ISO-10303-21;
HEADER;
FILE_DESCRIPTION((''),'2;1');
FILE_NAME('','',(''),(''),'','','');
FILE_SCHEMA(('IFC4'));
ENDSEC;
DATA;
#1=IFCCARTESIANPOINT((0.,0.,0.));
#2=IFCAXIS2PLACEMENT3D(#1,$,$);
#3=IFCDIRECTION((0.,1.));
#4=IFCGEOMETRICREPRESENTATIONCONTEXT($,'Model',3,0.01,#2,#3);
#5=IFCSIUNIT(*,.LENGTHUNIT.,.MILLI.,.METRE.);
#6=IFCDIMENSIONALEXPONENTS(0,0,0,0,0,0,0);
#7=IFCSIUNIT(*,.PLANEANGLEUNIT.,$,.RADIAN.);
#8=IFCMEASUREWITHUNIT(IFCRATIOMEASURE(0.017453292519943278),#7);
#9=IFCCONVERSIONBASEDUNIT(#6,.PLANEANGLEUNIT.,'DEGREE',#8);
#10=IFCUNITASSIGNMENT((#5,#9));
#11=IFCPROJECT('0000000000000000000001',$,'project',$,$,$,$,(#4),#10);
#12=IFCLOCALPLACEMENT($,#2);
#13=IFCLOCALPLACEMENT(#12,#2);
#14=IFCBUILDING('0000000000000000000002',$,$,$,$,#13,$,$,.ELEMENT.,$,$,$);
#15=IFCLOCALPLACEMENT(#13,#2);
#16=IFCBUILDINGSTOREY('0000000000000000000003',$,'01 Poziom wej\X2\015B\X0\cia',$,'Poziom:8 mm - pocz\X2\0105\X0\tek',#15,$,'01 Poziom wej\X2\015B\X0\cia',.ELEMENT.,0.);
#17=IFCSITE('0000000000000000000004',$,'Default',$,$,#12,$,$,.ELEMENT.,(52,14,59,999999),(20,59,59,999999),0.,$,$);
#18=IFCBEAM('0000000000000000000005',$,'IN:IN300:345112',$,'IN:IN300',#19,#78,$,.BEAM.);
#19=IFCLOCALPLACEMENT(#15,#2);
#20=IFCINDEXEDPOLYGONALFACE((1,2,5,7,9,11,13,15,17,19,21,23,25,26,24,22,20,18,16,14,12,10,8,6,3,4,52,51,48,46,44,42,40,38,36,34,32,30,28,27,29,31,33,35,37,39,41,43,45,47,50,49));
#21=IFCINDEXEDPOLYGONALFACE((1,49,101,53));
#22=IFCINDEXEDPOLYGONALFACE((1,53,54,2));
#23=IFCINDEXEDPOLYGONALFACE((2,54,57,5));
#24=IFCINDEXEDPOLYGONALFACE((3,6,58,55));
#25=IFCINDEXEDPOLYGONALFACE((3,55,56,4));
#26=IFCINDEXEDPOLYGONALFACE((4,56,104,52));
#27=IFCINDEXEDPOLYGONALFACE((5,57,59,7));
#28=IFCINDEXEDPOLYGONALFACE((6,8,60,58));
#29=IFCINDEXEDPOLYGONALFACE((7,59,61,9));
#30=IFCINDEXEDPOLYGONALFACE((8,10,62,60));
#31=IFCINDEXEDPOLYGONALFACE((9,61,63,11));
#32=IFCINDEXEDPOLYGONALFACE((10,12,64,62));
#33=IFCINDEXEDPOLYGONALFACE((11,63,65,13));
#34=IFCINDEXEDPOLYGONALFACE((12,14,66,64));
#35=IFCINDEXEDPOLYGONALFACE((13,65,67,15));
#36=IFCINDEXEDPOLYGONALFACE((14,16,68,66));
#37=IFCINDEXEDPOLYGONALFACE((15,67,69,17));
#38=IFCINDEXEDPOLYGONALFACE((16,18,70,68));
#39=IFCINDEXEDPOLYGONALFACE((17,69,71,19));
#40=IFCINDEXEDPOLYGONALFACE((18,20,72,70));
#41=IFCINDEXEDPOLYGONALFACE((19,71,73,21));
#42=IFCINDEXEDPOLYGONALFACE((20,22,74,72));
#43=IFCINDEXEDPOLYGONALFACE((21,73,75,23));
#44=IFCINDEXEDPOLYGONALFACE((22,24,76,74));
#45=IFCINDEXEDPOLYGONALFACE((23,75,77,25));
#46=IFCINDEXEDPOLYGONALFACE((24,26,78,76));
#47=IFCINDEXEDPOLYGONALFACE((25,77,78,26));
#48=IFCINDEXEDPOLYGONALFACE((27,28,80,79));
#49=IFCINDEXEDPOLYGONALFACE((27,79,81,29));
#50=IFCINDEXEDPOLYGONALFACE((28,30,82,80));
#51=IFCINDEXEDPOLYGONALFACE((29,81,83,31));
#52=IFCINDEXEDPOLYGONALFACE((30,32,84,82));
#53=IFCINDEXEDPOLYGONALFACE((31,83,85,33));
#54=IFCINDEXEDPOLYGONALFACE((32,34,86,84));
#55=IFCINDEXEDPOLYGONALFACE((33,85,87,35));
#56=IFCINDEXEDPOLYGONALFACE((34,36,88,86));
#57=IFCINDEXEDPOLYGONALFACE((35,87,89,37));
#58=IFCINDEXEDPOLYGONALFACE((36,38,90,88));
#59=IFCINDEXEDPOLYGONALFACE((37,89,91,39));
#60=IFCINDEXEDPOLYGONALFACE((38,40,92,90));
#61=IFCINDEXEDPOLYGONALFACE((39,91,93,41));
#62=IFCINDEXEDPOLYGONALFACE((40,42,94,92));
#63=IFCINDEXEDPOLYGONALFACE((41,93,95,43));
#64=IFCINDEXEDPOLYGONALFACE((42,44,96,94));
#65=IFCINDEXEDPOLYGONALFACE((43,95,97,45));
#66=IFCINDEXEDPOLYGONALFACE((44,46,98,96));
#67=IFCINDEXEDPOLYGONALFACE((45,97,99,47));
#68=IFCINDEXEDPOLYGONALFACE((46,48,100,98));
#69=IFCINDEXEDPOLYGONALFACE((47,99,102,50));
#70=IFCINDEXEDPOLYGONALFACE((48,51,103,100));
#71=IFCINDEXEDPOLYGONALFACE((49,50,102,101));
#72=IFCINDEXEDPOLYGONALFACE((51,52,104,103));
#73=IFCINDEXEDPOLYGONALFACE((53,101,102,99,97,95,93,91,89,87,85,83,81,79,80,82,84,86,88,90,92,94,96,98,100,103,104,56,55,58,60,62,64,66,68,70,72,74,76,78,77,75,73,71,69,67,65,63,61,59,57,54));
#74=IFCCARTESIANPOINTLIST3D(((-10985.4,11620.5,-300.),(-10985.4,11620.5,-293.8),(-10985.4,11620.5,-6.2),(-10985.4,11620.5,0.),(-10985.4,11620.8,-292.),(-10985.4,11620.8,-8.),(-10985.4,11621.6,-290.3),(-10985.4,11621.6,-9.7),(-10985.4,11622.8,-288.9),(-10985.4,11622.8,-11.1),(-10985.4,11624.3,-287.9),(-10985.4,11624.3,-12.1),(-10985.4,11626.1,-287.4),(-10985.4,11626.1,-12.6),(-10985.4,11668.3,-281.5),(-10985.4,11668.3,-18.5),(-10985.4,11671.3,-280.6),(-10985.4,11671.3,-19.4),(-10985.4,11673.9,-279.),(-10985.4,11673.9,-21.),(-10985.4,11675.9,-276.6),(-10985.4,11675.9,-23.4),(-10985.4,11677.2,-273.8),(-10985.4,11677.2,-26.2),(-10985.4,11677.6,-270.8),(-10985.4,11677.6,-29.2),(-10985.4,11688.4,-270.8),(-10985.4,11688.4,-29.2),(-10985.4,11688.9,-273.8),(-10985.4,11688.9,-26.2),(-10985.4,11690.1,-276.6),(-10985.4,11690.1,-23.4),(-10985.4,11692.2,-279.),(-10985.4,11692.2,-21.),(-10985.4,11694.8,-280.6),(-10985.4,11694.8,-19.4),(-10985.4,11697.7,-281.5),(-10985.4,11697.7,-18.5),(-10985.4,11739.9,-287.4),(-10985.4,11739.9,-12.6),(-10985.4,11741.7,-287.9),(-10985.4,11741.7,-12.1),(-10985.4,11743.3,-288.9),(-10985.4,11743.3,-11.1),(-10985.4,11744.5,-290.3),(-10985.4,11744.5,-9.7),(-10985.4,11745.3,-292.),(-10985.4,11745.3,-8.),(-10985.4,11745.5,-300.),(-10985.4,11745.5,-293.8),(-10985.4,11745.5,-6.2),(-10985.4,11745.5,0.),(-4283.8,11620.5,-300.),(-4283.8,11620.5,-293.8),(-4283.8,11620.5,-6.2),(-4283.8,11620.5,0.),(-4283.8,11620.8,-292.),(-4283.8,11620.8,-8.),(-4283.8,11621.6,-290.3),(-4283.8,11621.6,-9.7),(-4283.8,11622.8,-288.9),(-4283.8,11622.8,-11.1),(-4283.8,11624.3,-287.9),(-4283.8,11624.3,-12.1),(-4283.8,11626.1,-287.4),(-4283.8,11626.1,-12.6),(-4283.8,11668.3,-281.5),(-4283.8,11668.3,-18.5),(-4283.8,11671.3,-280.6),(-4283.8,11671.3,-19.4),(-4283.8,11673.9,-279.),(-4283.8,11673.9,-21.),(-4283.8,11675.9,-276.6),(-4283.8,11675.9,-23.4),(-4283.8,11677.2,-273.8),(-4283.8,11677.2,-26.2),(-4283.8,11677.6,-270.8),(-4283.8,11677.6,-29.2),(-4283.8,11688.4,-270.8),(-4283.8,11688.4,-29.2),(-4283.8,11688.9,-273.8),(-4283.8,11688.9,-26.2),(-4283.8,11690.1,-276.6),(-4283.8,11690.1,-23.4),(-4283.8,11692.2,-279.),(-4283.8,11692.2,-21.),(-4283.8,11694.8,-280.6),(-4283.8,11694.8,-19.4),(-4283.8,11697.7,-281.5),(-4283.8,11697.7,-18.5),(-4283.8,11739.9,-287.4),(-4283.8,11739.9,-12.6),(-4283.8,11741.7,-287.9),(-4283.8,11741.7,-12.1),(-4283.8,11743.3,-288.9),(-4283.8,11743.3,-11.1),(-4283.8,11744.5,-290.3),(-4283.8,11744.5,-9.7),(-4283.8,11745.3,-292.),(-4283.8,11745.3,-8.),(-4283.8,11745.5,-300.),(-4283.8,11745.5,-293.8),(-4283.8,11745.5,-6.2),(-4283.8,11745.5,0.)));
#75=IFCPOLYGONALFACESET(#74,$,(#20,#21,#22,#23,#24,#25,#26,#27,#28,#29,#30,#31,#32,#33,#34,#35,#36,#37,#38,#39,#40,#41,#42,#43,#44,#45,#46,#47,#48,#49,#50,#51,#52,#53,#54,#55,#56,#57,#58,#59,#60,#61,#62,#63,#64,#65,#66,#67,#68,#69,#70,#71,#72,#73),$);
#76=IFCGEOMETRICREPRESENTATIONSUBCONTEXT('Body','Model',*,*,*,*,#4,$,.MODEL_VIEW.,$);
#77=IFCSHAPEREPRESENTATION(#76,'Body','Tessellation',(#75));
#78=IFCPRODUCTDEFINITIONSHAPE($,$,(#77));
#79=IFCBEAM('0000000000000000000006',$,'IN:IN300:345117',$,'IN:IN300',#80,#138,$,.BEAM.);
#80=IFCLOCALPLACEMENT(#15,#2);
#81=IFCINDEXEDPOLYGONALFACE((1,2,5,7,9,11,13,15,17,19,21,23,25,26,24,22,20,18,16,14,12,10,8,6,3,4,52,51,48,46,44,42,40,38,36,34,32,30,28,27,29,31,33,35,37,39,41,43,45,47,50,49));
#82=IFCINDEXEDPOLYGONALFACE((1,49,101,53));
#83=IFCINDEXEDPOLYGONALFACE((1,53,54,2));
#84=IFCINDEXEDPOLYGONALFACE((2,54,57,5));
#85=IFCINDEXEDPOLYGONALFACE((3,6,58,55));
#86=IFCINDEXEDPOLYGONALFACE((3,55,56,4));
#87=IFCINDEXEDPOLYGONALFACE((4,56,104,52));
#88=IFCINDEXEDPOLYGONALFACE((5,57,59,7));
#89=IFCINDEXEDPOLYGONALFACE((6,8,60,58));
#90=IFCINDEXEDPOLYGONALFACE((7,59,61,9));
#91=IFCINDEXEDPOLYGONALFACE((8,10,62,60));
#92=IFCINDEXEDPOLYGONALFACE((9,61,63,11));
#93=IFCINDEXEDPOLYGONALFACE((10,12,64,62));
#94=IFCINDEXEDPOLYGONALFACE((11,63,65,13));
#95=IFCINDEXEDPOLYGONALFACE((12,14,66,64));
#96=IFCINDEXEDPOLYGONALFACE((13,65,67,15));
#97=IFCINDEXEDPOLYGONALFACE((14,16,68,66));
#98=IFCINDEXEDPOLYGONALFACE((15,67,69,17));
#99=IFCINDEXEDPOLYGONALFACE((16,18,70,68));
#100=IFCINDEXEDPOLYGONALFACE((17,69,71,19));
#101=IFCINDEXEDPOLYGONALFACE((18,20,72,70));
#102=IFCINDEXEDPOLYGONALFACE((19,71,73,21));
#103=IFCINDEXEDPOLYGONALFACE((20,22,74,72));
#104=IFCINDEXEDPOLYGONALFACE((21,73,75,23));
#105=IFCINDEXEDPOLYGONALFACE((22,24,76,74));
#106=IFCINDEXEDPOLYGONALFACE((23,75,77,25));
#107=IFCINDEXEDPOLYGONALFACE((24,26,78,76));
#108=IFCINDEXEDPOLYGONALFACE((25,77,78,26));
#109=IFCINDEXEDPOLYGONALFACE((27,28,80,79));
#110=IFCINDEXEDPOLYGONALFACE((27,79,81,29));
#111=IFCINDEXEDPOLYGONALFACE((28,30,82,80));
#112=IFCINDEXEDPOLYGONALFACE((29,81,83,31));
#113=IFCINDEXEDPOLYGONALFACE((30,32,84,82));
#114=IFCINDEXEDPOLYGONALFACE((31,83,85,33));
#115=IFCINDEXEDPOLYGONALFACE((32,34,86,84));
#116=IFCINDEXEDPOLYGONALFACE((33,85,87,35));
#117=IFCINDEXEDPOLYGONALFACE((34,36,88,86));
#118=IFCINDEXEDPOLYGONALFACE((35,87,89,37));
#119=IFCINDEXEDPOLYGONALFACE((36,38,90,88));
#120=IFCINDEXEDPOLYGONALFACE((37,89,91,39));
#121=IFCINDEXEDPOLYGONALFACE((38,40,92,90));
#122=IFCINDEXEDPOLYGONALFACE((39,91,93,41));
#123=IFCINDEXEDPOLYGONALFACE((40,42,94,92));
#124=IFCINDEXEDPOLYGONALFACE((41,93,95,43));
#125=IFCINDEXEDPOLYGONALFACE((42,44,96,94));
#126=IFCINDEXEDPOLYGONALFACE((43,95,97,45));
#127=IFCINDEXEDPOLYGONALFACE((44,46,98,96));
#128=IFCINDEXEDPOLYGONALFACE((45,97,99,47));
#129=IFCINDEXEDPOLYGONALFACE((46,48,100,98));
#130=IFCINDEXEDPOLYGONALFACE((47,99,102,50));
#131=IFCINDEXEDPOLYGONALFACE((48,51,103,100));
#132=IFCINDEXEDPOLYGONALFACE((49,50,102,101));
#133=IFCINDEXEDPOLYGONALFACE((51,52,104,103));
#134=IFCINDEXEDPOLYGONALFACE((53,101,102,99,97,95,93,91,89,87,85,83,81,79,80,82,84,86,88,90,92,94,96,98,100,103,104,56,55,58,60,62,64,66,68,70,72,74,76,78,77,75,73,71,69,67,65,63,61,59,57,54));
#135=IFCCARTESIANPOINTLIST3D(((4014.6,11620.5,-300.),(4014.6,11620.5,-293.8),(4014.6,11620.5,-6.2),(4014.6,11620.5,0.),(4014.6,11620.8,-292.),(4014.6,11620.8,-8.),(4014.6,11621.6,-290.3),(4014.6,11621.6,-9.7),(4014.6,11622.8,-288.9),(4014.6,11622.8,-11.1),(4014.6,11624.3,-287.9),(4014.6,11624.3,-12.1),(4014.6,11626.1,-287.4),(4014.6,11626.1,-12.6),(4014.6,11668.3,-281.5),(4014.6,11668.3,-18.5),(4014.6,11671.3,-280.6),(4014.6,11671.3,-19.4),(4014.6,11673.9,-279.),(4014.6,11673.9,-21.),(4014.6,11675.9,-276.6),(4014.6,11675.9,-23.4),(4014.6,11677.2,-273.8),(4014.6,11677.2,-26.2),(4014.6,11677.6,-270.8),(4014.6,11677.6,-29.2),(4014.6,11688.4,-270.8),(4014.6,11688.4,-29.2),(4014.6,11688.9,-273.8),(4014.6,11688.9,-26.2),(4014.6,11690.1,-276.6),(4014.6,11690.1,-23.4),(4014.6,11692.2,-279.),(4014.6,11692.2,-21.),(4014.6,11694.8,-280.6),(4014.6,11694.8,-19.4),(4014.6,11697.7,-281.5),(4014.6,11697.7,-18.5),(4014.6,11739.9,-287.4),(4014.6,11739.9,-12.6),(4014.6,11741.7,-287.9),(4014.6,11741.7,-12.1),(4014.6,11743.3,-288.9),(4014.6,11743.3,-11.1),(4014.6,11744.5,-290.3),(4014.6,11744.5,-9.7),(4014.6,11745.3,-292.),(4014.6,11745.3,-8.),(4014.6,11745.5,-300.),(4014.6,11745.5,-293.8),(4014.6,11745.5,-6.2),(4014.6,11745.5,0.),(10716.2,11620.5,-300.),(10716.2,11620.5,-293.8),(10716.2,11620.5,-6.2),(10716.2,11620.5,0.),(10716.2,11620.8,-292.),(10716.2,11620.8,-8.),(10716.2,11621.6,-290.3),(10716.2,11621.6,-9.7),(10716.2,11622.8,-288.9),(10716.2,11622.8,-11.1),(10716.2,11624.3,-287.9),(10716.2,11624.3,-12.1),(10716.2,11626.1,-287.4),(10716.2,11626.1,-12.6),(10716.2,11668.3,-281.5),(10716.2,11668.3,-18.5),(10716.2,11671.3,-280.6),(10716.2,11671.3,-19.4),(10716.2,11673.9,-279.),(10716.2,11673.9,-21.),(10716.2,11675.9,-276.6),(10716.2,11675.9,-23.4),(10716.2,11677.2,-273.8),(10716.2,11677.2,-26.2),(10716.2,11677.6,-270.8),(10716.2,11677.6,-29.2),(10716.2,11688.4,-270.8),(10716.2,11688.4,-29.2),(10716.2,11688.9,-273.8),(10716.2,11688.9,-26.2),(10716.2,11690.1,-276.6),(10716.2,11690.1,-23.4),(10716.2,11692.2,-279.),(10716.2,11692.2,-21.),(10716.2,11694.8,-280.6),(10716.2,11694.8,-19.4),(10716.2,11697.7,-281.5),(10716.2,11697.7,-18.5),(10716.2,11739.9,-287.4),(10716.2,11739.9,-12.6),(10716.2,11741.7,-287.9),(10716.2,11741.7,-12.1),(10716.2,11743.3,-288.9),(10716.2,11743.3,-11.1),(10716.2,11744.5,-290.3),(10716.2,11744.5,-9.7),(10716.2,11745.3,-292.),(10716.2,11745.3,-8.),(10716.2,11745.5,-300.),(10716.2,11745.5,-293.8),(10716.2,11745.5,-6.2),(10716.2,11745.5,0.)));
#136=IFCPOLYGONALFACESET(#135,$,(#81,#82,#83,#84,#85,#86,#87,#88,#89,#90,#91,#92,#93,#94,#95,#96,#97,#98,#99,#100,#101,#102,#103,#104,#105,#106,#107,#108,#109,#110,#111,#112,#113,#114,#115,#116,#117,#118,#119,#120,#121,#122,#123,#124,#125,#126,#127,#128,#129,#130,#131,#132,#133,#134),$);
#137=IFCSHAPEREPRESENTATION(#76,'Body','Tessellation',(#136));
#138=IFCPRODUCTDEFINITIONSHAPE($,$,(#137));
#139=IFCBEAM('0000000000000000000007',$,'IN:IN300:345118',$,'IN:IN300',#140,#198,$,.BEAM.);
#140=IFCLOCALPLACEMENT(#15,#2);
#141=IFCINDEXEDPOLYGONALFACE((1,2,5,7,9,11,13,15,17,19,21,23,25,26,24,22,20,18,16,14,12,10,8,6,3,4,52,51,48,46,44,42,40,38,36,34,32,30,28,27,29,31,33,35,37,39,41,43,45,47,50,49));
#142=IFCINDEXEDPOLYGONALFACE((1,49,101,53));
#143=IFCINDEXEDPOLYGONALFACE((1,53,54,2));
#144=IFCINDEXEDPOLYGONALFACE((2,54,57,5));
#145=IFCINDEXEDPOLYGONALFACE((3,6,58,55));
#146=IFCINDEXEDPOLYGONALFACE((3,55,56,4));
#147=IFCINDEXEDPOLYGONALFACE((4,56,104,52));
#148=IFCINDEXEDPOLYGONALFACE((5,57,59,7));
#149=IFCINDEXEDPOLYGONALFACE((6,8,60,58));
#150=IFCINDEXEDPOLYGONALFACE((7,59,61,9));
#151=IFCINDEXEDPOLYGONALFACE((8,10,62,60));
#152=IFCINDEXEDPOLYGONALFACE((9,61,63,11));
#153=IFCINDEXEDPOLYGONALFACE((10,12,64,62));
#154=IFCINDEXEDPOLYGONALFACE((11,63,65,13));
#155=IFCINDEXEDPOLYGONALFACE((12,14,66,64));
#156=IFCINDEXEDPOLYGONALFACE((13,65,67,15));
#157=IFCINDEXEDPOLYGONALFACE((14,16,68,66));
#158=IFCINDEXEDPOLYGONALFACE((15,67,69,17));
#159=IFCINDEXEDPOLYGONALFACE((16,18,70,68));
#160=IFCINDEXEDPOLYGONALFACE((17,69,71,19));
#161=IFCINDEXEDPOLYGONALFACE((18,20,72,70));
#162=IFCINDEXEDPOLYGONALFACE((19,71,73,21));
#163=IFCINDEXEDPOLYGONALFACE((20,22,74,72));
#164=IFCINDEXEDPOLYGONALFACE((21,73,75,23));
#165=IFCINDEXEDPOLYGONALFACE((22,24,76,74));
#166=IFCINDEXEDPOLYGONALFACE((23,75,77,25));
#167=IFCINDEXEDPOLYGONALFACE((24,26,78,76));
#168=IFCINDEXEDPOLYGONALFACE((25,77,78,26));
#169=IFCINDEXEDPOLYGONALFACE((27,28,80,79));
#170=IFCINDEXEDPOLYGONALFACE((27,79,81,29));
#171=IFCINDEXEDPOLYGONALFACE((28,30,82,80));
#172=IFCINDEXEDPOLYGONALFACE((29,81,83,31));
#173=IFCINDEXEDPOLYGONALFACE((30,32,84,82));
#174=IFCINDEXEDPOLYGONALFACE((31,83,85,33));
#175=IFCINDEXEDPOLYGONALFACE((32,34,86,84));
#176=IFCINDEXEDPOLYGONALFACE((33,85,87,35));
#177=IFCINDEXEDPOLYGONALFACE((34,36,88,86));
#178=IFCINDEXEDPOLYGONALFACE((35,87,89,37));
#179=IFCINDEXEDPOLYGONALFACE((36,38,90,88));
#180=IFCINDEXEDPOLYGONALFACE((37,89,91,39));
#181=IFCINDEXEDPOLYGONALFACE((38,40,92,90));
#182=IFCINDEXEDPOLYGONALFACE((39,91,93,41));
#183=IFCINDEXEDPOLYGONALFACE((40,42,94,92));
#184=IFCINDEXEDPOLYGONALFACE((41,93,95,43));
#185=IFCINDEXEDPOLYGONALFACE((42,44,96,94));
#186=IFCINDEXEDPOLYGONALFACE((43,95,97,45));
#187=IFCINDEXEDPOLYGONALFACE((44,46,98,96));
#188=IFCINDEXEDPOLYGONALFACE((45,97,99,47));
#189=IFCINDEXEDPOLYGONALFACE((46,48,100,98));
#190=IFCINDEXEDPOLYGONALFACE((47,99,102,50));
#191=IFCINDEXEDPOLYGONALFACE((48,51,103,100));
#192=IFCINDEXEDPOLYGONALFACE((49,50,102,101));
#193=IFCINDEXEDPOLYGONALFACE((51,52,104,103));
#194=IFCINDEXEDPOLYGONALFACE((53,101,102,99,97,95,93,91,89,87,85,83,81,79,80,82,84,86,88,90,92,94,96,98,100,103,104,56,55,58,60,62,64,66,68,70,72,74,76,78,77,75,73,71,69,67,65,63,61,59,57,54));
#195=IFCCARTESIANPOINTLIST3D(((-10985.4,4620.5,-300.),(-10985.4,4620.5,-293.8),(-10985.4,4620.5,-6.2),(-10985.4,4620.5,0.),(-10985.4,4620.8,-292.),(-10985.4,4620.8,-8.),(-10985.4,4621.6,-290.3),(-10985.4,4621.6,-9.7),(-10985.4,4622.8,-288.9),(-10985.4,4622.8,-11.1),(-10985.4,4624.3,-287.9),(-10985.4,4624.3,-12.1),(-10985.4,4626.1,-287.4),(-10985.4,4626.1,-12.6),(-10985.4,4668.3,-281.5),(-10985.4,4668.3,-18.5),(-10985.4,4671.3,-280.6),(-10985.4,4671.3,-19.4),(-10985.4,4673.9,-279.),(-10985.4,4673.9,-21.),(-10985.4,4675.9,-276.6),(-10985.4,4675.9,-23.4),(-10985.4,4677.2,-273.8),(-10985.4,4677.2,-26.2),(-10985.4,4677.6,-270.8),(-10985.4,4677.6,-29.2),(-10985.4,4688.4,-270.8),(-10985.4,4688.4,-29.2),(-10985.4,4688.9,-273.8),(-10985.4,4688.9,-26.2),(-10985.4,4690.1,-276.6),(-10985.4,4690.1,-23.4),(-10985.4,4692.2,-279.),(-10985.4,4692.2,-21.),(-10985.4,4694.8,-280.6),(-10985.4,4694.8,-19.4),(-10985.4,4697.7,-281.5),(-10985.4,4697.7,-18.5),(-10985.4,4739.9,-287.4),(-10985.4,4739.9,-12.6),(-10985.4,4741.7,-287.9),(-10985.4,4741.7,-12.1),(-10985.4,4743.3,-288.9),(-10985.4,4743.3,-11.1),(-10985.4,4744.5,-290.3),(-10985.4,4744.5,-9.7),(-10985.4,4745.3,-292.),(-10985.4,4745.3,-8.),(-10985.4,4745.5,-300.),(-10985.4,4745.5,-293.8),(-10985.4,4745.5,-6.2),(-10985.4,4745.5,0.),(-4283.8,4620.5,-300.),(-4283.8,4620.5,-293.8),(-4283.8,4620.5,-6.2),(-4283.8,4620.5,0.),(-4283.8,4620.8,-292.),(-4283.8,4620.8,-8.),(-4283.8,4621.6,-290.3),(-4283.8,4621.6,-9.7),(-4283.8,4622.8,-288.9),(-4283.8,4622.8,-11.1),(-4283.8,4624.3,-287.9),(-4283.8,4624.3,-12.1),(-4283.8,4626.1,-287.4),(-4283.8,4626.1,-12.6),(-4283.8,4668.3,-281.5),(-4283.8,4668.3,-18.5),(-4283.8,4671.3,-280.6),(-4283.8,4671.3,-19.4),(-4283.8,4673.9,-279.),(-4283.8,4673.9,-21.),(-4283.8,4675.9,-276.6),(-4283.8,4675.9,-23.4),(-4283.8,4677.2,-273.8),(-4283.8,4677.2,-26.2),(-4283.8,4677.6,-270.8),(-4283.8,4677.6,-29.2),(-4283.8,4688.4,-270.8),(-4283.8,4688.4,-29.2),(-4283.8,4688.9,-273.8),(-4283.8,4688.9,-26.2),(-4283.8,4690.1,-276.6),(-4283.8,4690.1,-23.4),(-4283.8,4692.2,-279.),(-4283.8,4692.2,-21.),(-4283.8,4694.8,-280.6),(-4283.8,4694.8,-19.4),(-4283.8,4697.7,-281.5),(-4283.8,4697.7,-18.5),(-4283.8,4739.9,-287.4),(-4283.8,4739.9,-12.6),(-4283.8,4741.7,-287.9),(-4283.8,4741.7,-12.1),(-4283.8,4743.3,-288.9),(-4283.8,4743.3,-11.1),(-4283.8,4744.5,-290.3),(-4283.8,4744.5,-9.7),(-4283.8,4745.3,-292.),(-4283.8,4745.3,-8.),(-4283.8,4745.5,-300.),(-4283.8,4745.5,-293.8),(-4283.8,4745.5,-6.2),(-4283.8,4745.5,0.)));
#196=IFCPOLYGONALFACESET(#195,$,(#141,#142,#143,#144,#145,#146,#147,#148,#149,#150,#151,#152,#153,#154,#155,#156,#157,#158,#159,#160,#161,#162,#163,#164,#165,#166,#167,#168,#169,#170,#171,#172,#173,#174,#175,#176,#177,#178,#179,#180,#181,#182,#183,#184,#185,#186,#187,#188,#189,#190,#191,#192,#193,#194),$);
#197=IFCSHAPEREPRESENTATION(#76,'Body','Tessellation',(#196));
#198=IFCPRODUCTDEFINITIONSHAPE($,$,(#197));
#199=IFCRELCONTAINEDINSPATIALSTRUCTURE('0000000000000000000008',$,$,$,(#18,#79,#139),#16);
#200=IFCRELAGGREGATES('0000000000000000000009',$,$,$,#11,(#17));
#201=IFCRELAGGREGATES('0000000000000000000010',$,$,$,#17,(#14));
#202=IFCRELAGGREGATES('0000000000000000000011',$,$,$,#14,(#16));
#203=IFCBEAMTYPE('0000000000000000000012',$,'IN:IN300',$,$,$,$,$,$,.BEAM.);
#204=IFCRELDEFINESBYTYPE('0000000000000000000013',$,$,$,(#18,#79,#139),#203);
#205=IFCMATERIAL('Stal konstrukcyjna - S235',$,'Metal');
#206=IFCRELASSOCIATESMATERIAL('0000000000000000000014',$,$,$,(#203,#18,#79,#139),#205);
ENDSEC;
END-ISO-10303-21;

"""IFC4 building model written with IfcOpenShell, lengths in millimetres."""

from ifc_helpers import new_model, entity, si_unit, converted_unit, direction, frame, origin, place, context, subcontext, project, spatial, line, arc, indexed_curve, outline, extrude, source, transform, mapped, material, type_object, type_shapes, element, save


model = new_model("IFC4")

# Units and contexts
model_context = context("Model", 3, precision=0.01, world=origin(), true_north=direction((0.0, 1.0)))
body_context = subcontext(model_context, "Body", "Model", "MODEL_VIEW")
ifc_project = project(units=[si_unit("LENGTHUNIT", "METRE", prefix="MILLI"), converted_unit("PLANEANGLEUNIT", "DEGREE", entity("IfcRatioMeasure", 0.017453292519943278), si_unit("PLANEANGLEUNIT", "RADIAN"), dimensions=[0, 0, 0, 0, 0, 0, 0])], contexts=[model_context])

# Site, building, storey
site_placement = place(None, origin())
site = spatial("IfcSite", under=ifc_project, at=site_placement, Name="Default", CompositionType="ELEMENT", RefLatitude=(52, 14, 59, 999999), RefLongitude=(20, 59, 59, 999999), RefElevation=0.0)
building_placement = place(site_placement, origin())
building = spatial("IfcBuilding", under=site, at=building_placement, CompositionType="ELEMENT")
storey_placement = place(building_placement, origin())
storey = spatial("IfcBuildingStorey", under=building, at=storey_placement, Name="01 Poziom wejścia", ObjectType="Poziom:8 mm - początek", LongName="01 Poziom wejścia", CompositionType="ELEMENT", Elevation=0.0)

# Beams
ifc_material = material(Name="Stal konstrukcyjna - S235", Category="Metal")
beam_type_1 = type_object("IfcBeamType", Name="IN:IN300", PredefinedType="BEAM", material=ifc_material)
shared_shape_1 = source(origin(), body_context, "Body", "SweptSolid", [
    extrude(outline(indexed_curve([(143.8, -62.5), (150.0, -62.5), (150.0, 62.5), (143.8, 62.5), (139.6, 60.9), (137.4, 56.9), (131.5, 14.7), (127.9, 8.1), (120.8, 5.4), (-120.8, 5.4), (-127.9, 8.1), (-131.5, 14.7), (-137.4, 56.9), (-139.6, 60.9), (-143.8, 62.5), (-150.0, 62.5), (-150.0, -62.5), (-143.8, -62.5), (-139.6, -60.9), (-137.4, -56.9), (-131.5, -14.7), (-127.9, -8.1), (-120.8, -5.4), (120.8, -5.4), (127.9, -8.1), (131.5, -14.7), (137.4, -56.9), (139.6, -60.9)], segments=[line(1, 2, 3, 4), arc(4, 5, 6), line(6, 7), arc(7, 8, 9), line(9, 10), arc(10, 11, 12), line(12, 13), arc(13, 14, 15), line(15, 16, 17, 18), arc(18, 19, 20), line(20, 21), arc(21, 22, 23), line(23, 24), arc(24, 25, 26), line(26, 27), arc(27, 28, 1)], self_intersect=False)), frame((-3350.8, 0.0, 0.0), z_axis=(1.0, 0.0, 0.0), x_axis=(0.0, 0.0, -1.0)), (0.0, 0.0, 1.0), 6701.6),
])
type_shapes(beam_type_1, [shared_shape_1])
for number, where, name in (
    (1, (-7634.6, 11683.0, -150.0), "IN:IN300:345112"),
    (2, (7365.4, 11683.0, -150.0), "IN:IN300:345117"),
    (3, (-7634.6, 4683.0, -150.0), "IN:IN300:345118"),
):
    element("IfcBeam", number, at=place(storey_placement, frame(where)), inside=storey, type_object=beam_type_1, material=ifc_material, Name=name, ObjectType="IN:IN300", PredefinedType="BEAM", context=body_context, shape_type="MappedRepresentation", body=[
        mapped(shared_shape_1, transform((0.0, 0.0, 0.0), scale=1.0)),
    ])

save(model, "model.ifc")
